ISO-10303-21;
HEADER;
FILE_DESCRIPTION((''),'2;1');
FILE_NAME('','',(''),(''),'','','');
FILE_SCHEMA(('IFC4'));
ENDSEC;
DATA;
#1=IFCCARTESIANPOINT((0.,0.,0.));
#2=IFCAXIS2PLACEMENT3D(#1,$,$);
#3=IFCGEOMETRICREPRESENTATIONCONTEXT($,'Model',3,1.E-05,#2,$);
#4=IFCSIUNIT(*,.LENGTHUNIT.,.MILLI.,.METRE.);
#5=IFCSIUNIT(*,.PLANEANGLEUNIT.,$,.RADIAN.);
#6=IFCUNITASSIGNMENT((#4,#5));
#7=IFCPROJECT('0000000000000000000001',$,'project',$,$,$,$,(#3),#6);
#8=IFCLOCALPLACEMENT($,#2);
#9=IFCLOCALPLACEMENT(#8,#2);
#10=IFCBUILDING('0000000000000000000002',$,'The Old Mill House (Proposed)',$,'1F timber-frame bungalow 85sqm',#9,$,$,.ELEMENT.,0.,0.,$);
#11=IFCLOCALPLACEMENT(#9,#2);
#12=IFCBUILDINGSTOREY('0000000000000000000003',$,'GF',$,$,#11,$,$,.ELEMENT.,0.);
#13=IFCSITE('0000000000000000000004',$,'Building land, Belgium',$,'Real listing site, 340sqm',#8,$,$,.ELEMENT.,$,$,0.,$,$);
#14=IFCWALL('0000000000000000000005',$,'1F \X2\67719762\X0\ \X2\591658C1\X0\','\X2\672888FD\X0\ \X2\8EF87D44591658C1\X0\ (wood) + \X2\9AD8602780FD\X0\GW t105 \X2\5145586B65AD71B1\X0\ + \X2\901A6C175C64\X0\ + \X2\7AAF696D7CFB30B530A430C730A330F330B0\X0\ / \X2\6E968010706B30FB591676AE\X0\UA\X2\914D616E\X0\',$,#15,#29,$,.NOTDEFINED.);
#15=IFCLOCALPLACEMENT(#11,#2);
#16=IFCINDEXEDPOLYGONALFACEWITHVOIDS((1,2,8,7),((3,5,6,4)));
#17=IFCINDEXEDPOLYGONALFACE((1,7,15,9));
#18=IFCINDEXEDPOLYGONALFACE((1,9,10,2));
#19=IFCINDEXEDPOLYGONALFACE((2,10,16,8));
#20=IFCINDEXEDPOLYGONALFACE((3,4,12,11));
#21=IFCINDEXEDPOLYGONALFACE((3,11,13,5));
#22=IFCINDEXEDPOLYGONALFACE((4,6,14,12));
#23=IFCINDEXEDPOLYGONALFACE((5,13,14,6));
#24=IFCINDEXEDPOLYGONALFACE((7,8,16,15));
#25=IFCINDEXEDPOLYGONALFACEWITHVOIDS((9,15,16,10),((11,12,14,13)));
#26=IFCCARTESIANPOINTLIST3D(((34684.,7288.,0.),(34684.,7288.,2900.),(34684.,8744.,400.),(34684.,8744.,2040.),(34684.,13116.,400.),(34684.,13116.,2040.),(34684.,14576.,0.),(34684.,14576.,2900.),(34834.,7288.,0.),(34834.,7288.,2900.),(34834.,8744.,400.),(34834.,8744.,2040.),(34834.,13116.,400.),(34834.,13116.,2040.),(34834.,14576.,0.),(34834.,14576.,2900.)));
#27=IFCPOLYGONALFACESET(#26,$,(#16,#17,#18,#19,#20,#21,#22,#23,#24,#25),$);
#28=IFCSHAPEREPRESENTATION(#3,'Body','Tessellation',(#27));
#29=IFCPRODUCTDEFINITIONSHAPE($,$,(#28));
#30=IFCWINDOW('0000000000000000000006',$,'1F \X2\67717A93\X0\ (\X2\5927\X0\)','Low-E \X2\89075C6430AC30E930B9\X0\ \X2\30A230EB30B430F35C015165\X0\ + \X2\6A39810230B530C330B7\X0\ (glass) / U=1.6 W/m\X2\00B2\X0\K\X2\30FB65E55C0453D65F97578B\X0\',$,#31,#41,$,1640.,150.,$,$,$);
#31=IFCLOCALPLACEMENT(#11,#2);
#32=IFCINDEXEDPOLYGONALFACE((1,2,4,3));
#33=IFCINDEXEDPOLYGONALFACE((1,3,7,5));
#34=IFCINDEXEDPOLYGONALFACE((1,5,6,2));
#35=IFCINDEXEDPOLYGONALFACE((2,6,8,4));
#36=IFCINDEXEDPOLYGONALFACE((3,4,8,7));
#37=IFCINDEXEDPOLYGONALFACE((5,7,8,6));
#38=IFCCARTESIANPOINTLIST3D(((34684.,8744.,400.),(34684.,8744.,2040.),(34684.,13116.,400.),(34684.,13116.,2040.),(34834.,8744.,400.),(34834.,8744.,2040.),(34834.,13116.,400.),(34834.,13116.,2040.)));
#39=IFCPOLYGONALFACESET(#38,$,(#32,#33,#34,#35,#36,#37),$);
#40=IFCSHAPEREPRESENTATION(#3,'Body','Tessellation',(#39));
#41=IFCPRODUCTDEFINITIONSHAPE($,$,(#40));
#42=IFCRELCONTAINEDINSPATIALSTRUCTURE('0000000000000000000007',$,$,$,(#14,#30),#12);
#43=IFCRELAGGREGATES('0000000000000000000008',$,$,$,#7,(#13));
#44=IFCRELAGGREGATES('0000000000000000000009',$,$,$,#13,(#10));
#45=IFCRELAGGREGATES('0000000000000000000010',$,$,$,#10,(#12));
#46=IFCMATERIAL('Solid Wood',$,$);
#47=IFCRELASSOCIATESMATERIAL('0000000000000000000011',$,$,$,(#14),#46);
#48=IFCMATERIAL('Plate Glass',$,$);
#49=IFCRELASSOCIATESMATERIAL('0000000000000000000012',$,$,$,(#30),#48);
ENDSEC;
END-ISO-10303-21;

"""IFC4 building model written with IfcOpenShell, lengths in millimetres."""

from ifc_helpers import new_model, si_unit, frame, frame_2d, origin, place, context, project, spatial, rectangle, extrude, material, element, fill, save


model = new_model("IFC4")

# Units and contexts
model_context = context("Model", 3, precision=1e-05, world=origin())
ifc_project = project(units=[si_unit("LENGTHUNIT", "METRE", prefix="MILLI"), si_unit("PLANEANGLEUNIT", "RADIAN")], contexts=[model_context])

# Site, building, storey
site_placement = place(None, origin())
site = spatial("IfcSite", under=ifc_project, at=site_placement, Name="Building land, Belgium", ObjectType="Real listing site, 340sqm", CompositionType="ELEMENT", RefElevation=0.0)
building_placement = place(site_placement, origin())
building = spatial("IfcBuilding", under=site, at=building_placement, Name="The Old Mill House (Proposed)", ObjectType="1F timber-frame bungalow 85sqm", CompositionType="ELEMENT", ElevationOfRefHeight=0.0, ElevationOfTerrain=0.0)
storey_placement = place(building_placement, origin())
storey = spatial("IfcBuildingStorey", under=building, at=storey_placement, Name="GF", CompositionType="ELEMENT", Elevation=0.0)

# Shared definitions
ifc_material_1 = material(Name="Solid Wood")

# Wall, opening, window
wall_1_placement = place(storey_placement, frame((17342.0, 3644.0, 0.0)))
wall_1 = element("IfcWall", 1, at=wall_1_placement, inside=storey, material=ifc_material_1, Name="1F 東面 外壁", Description="木製 軸組外壁 (wood) + 高性能GW t105 充填断熱 + 通気層 + 窯業系サイディング / 準耐火・外皮UA配慮", PredefinedType="NOTDEFINED", context=model_context, shape_type="SweptSolid", body=[
    extrude(rectangle(XDim=150.0, YDim=7288.0, at=frame_2d((75.0, 3644.0))), frame((17342.0, 3644.0, 0.0)), (0.0, 0.0, 1.0), 2900.0),
])
opening_placement = place(storey_placement, frame((17342.0, 4372.0, 200.0)))
opening = element("IfcOpeningElement", 2, at=opening_placement, cuts=wall_1, PredefinedType="NOTDEFINED", context=model_context, shape_type="SweptSolid", body=[
    extrude(rectangle(XDim=150.0, YDim=4372.0, at=frame_2d((75.0, 2186.0))), frame((17342.0, 4372.0, 200.0)), (0.0, 0.0, 1.0), 1640.0),
])
ifc_material_2 = material(Name="Plate Glass")
window_1_placement = place(storey_placement, frame((17342.0, 4372.0, 200.0)))
window_1 = element("IfcWindow", 3, at=window_1_placement, inside=storey, material=ifc_material_2, Name="1F 東窓 (大)", Description="Low-E 複層ガラス アルゴン封入 + 樹脂サッシ (glass) / U=1.6 W/m²K・日射取得型", OverallHeight=1640.0, OverallWidth=150.0, context=model_context, shape_type="SweptSolid", body=[
    extrude(rectangle(XDim=150.0, YDim=4372.0, at=frame_2d((75.0, 2186.0))), frame((17342.0, 4372.0, 200.0)), (0.0, 0.0, 1.0), 1640.0),
])
fill(opening, window_1)

save(model, "model.ifc")
